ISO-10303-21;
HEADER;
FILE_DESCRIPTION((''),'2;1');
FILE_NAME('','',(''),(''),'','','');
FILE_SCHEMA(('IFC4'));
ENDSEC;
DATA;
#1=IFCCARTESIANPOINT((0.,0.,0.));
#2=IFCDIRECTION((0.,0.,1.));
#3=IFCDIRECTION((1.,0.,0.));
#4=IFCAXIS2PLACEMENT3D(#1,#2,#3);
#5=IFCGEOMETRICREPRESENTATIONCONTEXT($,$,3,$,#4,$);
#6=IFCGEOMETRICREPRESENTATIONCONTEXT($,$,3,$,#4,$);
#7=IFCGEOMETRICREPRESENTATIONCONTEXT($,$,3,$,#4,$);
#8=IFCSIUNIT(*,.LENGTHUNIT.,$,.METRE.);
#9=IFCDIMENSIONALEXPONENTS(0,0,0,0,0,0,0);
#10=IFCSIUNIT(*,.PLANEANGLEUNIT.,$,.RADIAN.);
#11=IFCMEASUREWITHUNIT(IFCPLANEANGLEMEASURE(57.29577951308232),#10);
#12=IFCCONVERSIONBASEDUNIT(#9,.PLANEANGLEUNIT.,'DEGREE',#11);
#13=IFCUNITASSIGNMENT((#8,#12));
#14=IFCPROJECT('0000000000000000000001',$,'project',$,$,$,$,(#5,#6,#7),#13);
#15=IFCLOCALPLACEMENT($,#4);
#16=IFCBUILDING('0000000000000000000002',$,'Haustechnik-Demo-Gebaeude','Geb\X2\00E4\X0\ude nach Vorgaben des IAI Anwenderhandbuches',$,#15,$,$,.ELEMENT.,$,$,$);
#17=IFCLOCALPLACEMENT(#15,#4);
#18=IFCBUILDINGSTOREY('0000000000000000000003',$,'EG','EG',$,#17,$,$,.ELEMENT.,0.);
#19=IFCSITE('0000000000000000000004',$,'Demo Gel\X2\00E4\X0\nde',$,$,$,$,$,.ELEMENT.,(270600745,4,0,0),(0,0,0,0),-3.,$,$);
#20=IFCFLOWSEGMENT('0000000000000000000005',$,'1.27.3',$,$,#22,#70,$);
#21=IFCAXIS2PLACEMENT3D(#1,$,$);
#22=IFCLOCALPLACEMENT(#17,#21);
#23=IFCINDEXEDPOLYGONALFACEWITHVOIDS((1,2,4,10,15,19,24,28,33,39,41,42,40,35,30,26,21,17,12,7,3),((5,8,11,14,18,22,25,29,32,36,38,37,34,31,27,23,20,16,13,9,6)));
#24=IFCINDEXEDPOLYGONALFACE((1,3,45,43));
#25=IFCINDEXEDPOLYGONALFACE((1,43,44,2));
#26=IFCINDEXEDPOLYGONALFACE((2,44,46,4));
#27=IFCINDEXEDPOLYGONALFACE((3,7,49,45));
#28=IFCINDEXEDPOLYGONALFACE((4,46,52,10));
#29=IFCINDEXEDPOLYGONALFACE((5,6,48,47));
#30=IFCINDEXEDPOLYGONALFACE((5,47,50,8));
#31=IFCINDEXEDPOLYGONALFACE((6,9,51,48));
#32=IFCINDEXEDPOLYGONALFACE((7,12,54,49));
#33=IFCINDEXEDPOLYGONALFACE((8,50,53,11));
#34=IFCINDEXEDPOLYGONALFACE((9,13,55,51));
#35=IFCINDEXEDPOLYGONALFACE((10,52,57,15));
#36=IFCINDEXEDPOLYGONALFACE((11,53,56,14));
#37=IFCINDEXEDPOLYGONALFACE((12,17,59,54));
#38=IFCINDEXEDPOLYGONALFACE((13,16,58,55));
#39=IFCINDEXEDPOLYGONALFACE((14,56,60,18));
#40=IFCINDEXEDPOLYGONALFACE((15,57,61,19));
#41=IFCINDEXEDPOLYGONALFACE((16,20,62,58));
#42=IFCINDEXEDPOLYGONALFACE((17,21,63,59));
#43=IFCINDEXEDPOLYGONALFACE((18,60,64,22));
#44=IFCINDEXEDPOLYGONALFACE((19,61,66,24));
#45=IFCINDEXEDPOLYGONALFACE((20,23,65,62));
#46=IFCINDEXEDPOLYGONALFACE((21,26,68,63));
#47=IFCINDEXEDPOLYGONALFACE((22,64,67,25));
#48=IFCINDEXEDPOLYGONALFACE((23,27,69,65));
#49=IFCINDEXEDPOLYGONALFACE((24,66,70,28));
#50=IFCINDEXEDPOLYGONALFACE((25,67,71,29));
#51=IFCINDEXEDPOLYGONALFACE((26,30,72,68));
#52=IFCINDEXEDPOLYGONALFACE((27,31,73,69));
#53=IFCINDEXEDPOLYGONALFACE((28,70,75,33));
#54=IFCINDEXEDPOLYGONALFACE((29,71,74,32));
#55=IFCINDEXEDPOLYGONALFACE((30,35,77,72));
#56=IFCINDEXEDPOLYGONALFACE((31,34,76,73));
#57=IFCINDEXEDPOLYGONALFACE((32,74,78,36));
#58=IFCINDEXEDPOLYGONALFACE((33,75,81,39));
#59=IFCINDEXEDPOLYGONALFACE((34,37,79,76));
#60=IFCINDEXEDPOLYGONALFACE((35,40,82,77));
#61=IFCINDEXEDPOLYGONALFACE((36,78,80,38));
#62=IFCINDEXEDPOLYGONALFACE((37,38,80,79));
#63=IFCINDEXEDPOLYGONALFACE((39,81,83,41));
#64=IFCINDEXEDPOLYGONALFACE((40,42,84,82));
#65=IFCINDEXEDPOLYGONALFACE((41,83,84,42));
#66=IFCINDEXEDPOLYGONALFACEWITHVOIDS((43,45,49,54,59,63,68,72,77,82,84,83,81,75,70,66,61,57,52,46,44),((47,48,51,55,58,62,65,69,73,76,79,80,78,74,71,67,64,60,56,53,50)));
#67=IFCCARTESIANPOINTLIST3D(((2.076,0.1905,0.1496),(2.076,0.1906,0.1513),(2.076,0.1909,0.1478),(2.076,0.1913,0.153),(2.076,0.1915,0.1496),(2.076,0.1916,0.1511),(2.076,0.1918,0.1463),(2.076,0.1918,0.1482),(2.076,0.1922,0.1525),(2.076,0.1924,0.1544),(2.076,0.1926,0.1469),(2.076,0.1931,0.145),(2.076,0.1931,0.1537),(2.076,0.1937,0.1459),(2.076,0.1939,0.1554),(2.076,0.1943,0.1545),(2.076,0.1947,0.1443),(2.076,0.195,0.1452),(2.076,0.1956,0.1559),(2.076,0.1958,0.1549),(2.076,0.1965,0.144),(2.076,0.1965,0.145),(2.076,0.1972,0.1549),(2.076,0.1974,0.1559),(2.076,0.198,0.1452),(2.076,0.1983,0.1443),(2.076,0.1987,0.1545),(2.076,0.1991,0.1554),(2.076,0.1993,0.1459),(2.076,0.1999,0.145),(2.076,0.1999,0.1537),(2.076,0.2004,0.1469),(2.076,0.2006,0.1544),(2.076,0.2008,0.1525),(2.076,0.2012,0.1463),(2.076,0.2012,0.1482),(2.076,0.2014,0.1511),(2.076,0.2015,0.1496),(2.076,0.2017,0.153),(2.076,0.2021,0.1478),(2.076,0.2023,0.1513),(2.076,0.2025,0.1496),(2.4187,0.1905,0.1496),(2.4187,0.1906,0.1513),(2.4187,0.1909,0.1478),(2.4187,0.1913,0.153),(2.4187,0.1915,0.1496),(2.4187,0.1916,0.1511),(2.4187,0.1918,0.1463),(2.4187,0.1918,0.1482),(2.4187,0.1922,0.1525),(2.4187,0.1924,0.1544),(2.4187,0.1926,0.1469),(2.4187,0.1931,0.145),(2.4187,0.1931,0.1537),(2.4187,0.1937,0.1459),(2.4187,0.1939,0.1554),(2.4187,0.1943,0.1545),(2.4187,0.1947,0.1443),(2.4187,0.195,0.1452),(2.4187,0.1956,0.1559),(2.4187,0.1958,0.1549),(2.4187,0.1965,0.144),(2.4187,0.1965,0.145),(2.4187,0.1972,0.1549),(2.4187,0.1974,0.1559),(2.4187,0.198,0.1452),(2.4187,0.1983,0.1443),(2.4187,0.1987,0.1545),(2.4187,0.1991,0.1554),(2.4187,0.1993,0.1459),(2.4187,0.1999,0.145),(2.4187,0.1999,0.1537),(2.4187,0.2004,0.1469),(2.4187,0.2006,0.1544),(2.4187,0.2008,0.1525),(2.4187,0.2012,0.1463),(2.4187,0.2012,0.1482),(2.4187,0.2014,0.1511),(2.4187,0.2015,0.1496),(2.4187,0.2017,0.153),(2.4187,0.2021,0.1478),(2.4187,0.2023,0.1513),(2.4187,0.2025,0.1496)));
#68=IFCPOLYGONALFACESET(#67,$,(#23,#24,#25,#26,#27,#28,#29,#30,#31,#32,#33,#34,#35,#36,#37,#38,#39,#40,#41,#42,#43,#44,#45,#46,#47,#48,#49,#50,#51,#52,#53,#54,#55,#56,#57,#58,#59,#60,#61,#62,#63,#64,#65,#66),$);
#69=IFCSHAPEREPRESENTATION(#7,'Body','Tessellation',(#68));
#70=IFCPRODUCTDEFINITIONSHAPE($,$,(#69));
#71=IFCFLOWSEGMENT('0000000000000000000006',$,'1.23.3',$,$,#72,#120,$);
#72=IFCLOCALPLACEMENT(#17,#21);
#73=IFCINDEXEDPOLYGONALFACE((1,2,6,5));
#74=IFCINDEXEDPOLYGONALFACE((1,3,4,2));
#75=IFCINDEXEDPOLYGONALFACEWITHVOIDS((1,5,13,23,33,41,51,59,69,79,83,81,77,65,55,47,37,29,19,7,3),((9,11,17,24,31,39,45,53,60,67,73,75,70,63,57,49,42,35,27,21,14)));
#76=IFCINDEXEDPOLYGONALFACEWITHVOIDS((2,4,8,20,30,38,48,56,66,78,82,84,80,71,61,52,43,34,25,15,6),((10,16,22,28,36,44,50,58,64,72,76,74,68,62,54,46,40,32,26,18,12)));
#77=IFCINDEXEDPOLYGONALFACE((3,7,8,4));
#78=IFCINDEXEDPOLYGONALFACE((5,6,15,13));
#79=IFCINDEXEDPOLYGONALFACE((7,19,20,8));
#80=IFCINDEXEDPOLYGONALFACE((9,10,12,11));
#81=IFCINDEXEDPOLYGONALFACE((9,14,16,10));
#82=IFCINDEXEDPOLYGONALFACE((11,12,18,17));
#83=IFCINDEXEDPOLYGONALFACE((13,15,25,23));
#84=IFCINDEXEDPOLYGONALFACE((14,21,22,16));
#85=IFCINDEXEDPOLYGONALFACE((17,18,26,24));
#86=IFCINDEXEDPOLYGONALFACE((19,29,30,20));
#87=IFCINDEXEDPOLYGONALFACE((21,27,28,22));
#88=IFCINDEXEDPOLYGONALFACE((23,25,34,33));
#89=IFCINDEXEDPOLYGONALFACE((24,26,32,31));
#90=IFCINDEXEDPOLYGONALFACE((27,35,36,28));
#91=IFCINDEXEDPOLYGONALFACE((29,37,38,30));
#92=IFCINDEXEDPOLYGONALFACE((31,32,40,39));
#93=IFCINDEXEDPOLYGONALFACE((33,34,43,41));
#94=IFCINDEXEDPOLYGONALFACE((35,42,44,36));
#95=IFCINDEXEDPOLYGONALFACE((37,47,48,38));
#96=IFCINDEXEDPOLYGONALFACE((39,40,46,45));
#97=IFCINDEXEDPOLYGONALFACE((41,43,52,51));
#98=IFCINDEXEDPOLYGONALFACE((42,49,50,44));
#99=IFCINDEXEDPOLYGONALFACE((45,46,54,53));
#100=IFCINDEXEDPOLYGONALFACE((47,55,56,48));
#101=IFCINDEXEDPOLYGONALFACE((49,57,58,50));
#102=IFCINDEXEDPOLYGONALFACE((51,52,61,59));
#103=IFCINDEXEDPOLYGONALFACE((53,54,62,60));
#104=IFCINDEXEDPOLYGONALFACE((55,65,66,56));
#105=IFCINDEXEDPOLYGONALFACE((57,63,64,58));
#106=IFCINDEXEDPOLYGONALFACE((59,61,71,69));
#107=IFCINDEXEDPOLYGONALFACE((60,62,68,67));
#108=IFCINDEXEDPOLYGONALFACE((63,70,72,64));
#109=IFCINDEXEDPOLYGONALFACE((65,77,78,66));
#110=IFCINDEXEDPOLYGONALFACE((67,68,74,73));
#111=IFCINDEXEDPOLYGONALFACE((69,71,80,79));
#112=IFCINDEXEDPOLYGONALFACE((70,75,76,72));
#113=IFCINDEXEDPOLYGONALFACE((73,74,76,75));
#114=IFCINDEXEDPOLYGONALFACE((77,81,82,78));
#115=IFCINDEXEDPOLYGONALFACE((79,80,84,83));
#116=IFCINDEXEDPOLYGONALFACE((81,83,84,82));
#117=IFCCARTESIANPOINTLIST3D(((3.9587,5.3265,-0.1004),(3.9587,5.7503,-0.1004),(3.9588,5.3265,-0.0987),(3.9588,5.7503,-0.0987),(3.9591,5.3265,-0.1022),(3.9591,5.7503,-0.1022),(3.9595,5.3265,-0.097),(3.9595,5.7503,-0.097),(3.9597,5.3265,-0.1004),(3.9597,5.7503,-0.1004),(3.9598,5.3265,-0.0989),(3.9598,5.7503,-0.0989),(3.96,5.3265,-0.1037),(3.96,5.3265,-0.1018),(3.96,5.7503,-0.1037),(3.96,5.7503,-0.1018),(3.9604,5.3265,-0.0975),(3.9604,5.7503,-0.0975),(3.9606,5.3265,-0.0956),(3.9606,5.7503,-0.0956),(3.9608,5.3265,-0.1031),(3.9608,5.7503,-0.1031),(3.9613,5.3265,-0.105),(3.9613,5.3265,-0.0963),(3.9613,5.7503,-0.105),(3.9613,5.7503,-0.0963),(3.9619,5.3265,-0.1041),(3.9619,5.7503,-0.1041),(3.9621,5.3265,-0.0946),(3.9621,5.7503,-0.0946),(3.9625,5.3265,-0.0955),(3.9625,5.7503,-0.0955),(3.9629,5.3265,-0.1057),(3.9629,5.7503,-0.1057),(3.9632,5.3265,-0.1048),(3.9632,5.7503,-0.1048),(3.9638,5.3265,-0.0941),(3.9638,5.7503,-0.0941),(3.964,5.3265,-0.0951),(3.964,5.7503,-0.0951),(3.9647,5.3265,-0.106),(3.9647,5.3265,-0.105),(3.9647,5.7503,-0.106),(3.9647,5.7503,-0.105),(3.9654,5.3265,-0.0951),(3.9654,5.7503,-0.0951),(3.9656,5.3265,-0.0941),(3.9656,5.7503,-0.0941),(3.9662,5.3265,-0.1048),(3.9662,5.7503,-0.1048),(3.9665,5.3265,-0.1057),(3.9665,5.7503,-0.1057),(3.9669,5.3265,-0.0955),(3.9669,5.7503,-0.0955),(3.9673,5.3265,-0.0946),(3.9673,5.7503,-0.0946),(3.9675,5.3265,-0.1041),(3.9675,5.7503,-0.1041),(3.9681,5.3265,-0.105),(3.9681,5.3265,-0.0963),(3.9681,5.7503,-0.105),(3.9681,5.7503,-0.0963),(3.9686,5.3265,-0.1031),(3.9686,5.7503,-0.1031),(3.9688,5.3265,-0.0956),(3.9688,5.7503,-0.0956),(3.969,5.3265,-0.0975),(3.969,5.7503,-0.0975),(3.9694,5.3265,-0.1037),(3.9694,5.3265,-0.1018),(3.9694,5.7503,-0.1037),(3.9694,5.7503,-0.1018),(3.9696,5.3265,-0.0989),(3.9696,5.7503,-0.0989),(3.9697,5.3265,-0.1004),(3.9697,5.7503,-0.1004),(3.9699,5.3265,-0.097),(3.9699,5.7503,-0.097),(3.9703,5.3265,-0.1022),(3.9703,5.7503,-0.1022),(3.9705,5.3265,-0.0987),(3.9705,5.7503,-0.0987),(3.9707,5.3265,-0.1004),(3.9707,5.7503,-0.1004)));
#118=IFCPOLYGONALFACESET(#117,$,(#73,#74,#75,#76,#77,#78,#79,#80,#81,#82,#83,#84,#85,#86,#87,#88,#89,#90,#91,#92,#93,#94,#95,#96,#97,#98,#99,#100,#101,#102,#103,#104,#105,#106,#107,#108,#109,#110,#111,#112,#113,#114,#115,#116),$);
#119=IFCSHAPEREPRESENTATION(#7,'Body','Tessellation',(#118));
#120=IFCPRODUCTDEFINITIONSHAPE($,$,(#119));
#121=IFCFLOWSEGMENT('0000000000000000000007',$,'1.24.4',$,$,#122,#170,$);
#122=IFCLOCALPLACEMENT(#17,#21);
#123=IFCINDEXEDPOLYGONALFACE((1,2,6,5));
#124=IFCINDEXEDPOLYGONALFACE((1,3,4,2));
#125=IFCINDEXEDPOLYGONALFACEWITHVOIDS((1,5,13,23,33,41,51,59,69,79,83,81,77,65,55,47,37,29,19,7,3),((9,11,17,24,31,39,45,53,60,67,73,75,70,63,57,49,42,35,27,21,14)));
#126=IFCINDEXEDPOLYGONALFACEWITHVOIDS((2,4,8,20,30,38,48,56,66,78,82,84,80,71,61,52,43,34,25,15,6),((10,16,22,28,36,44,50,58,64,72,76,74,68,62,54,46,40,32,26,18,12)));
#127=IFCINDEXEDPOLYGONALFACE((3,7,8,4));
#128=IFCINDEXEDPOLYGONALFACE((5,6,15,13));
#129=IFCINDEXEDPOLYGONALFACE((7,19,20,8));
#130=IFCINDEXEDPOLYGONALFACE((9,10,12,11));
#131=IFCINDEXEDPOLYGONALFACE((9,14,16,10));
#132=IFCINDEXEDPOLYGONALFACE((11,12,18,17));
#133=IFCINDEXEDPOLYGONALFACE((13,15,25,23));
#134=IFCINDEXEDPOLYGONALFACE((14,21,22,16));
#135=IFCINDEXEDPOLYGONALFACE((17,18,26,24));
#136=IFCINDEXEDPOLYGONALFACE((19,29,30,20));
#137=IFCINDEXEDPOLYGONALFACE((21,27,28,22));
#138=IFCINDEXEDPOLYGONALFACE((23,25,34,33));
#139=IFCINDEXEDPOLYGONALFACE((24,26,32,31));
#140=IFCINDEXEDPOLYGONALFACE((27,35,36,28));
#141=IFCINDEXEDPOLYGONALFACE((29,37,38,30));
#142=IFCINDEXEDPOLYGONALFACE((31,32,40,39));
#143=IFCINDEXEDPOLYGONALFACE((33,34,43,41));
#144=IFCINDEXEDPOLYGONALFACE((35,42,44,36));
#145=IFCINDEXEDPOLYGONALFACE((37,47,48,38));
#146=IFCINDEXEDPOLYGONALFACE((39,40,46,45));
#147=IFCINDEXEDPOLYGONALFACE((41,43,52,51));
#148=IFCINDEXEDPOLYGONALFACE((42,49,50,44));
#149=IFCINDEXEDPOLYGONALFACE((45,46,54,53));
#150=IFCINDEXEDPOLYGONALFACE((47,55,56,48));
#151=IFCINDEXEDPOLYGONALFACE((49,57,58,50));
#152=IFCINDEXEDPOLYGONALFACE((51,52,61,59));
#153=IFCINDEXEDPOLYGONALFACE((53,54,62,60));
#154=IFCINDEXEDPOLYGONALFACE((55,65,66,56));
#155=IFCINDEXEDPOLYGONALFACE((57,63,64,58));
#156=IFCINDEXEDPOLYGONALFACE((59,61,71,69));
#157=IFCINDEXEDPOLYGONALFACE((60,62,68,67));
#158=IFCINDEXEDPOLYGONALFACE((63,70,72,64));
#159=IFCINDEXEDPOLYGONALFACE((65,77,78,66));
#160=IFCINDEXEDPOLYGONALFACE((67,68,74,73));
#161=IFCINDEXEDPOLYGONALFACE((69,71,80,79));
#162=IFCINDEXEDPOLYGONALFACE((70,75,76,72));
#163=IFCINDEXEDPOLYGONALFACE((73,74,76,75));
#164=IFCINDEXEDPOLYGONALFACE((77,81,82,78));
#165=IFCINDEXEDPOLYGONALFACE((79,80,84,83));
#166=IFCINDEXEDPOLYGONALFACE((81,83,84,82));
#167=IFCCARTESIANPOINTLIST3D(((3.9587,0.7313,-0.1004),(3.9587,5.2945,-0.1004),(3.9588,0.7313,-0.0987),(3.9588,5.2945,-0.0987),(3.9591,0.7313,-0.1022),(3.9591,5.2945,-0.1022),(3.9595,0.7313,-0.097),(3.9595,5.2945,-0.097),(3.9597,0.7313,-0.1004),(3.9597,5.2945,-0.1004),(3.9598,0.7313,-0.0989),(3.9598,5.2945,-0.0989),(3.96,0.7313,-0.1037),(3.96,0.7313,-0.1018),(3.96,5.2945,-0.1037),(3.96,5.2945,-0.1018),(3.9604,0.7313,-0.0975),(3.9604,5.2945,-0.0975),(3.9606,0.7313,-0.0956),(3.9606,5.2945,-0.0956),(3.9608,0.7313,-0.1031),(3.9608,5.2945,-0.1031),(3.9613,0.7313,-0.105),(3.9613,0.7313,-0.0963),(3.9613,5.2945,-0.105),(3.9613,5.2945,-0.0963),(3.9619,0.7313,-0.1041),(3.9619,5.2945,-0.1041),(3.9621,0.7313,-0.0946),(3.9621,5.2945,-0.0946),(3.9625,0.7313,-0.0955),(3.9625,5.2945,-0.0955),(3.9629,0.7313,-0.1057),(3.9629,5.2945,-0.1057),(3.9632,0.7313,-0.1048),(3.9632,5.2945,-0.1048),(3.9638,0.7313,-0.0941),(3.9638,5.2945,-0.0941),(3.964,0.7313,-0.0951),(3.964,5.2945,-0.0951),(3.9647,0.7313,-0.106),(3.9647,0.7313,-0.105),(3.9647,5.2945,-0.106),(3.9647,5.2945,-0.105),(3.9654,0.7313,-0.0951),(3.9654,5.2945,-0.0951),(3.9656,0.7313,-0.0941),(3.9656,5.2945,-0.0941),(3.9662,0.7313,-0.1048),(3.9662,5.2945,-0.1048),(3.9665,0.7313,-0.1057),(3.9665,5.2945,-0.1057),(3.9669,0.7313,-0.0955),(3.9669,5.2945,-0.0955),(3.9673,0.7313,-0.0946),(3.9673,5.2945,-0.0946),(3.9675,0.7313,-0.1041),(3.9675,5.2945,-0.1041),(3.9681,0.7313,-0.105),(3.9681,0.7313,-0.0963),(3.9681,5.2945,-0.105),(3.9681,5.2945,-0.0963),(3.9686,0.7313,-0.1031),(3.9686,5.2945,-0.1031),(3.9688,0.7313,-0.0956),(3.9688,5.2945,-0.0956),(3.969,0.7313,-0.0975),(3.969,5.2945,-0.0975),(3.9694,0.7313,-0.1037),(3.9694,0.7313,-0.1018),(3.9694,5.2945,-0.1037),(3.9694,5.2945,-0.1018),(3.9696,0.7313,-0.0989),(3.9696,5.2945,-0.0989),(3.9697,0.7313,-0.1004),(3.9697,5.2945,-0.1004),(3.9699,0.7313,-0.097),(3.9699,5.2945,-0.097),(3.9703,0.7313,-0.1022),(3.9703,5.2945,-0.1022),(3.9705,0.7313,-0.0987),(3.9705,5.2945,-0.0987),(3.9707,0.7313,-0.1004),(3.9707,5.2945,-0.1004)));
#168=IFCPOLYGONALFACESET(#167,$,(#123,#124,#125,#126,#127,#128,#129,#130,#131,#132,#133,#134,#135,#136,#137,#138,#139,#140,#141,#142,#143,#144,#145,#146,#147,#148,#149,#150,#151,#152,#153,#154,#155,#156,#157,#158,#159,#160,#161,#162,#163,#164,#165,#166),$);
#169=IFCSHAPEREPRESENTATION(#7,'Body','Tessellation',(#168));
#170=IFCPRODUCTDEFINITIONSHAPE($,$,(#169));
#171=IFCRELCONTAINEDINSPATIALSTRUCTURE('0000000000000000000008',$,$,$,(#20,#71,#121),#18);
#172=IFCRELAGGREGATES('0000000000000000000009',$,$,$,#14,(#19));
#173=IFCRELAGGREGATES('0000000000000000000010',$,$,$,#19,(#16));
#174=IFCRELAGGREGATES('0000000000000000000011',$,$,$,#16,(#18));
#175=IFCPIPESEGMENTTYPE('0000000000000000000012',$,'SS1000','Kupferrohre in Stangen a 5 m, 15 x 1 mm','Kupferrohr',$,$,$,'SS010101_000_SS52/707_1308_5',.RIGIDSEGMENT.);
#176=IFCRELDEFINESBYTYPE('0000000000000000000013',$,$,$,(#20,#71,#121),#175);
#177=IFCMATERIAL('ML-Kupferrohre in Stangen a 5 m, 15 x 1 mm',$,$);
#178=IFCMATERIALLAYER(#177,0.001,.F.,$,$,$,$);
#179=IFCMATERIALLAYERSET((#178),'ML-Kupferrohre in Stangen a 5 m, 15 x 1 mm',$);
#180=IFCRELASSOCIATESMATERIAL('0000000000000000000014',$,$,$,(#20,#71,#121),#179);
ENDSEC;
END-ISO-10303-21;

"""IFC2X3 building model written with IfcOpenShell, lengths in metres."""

from ifc_helpers import new_model, entity, si_unit, converted_unit, frame, origin_with_axes, origin_2d_with_axis, place, context, project, spatial, hollow_circle, extrude, material, layer, layer_set, layer_usage, type_object, element, save


model = new_model("IFC2X3")

# Units and contexts
context_of_model_1 = context(None, 3, world=origin_with_axes())
context_of_model_2 = context(None, 3, world=origin_with_axes())
context_of_model_3 = context(None, 3, world=origin_with_axes())
ifc_project = project(units=[si_unit("LENGTHUNIT", "METRE"), converted_unit("PLANEANGLEUNIT", "DEGREE", entity("IfcPlaneAngleMeasure", 57.29577951308232), si_unit("PLANEANGLEUNIT", "RADIAN"), dimensions=[0, 0, 0, 0, 0, 0, 0])], contexts=[context_of_model_1, context_of_model_2, context_of_model_3])

# Site, building, storey
site = spatial("IfcSite", under=ifc_project, Name="Demo Gelände", CompositionType="ELEMENT", RefLatitude=(270600745, 4, 0, 0), RefLongitude=(0, 0, 0, 0), RefElevation=-3.0)
building_placement = place(None, origin_with_axes())
building = spatial("IfcBuilding", under=site, at=building_placement, Name="Haustechnik-Demo-Gebaeude", Description="Gebäude nach Vorgaben des IAI Anwenderhandbuches", CompositionType="ELEMENT")
storey_placement = place(building_placement, origin_with_axes())
storey = spatial("IfcBuildingStorey", under=building, at=storey_placement, Name="EG", Description="EG", CompositionType="ELEMENT", Elevation=0.0)

# Flow segments
ifc_material = material(Name="ML-Kupferrohre in Stangen a 5 m, 15 x 1 mm")
ifc_layer = layer(ifc_material, 0.001, ventilated=False)
ifc_layer_set = layer_set([ifc_layer], Name="ML-Kupferrohre in Stangen a 5 m, 15 x 1 mm")
ifc_layer_usage = layer_usage(ifc_layer_set, "AXIS2", "POSITIVE", 0.0)
pipe_segment_type_1 = type_object("IfcPipeSegmentType", Name="SS1000", Description="Kupferrohre in Stangen a 5 m, 15 x 1 mm", ApplicableOccurrence="Kupferrohr", ElementType="SS010101_000_SS52/707_1308_5", PredefinedType="RIGIDSEGMENT")
flow_segment_1_placement = place(storey_placement, frame((2.4187, 0.1965, 0.15), z_axis=(-1.0, 0.000001, 0.0), x_axis=(0.0, 0.0, -1.0)))
element("IfcFlowSegment", 1, at=flow_segment_1_placement, inside=storey, type_object=pipe_segment_type_1, material=ifc_layer_usage, Name="1.27.3", context=context_of_model_3, shape_type="SweptSolid", body=[
    extrude(hollow_circle(Radius=0.006, WallThickness=0.001, at=origin_2d_with_axis()), origin_with_axes(), (0.0, 0.0, 1.0), 0.3427),
])
flow_segment_2_placement = place(storey_placement, frame((3.9647, 5.7503, -0.1), z_axis=(0.0, -1.0, 0.0), x_axis=(0.0, 0.0, -1.0)))
element("IfcFlowSegment", 2, at=flow_segment_2_placement, inside=storey, type_object=pipe_segment_type_1, material=ifc_layer_usage, Name="1.23.3", context=context_of_model_3, shape_type="SweptSolid", body=[
    extrude(hollow_circle(Radius=0.006, WallThickness=0.001, at=origin_2d_with_axis()), origin_with_axes(), (0.0, 0.0, 1.0), 0.4238),
])
flow_segment_3_placement = place(storey_placement, frame((3.9647, 5.2945, -0.1), z_axis=(0.0, -1.0, 0.0), x_axis=(0.0, 0.0, -1.0)))
element("IfcFlowSegment", 3, at=flow_segment_3_placement, inside=storey, type_object=pipe_segment_type_1, material=ifc_layer_usage, Name="1.24.4", context=context_of_model_3, shape_type="SweptSolid", body=[
    extrude(hollow_circle(Radius=0.006, WallThickness=0.001, at=origin_2d_with_axis()), origin_with_axes(), (0.0, 0.0, 1.0), 4.5632),
])

save(model, "model.ifc")
